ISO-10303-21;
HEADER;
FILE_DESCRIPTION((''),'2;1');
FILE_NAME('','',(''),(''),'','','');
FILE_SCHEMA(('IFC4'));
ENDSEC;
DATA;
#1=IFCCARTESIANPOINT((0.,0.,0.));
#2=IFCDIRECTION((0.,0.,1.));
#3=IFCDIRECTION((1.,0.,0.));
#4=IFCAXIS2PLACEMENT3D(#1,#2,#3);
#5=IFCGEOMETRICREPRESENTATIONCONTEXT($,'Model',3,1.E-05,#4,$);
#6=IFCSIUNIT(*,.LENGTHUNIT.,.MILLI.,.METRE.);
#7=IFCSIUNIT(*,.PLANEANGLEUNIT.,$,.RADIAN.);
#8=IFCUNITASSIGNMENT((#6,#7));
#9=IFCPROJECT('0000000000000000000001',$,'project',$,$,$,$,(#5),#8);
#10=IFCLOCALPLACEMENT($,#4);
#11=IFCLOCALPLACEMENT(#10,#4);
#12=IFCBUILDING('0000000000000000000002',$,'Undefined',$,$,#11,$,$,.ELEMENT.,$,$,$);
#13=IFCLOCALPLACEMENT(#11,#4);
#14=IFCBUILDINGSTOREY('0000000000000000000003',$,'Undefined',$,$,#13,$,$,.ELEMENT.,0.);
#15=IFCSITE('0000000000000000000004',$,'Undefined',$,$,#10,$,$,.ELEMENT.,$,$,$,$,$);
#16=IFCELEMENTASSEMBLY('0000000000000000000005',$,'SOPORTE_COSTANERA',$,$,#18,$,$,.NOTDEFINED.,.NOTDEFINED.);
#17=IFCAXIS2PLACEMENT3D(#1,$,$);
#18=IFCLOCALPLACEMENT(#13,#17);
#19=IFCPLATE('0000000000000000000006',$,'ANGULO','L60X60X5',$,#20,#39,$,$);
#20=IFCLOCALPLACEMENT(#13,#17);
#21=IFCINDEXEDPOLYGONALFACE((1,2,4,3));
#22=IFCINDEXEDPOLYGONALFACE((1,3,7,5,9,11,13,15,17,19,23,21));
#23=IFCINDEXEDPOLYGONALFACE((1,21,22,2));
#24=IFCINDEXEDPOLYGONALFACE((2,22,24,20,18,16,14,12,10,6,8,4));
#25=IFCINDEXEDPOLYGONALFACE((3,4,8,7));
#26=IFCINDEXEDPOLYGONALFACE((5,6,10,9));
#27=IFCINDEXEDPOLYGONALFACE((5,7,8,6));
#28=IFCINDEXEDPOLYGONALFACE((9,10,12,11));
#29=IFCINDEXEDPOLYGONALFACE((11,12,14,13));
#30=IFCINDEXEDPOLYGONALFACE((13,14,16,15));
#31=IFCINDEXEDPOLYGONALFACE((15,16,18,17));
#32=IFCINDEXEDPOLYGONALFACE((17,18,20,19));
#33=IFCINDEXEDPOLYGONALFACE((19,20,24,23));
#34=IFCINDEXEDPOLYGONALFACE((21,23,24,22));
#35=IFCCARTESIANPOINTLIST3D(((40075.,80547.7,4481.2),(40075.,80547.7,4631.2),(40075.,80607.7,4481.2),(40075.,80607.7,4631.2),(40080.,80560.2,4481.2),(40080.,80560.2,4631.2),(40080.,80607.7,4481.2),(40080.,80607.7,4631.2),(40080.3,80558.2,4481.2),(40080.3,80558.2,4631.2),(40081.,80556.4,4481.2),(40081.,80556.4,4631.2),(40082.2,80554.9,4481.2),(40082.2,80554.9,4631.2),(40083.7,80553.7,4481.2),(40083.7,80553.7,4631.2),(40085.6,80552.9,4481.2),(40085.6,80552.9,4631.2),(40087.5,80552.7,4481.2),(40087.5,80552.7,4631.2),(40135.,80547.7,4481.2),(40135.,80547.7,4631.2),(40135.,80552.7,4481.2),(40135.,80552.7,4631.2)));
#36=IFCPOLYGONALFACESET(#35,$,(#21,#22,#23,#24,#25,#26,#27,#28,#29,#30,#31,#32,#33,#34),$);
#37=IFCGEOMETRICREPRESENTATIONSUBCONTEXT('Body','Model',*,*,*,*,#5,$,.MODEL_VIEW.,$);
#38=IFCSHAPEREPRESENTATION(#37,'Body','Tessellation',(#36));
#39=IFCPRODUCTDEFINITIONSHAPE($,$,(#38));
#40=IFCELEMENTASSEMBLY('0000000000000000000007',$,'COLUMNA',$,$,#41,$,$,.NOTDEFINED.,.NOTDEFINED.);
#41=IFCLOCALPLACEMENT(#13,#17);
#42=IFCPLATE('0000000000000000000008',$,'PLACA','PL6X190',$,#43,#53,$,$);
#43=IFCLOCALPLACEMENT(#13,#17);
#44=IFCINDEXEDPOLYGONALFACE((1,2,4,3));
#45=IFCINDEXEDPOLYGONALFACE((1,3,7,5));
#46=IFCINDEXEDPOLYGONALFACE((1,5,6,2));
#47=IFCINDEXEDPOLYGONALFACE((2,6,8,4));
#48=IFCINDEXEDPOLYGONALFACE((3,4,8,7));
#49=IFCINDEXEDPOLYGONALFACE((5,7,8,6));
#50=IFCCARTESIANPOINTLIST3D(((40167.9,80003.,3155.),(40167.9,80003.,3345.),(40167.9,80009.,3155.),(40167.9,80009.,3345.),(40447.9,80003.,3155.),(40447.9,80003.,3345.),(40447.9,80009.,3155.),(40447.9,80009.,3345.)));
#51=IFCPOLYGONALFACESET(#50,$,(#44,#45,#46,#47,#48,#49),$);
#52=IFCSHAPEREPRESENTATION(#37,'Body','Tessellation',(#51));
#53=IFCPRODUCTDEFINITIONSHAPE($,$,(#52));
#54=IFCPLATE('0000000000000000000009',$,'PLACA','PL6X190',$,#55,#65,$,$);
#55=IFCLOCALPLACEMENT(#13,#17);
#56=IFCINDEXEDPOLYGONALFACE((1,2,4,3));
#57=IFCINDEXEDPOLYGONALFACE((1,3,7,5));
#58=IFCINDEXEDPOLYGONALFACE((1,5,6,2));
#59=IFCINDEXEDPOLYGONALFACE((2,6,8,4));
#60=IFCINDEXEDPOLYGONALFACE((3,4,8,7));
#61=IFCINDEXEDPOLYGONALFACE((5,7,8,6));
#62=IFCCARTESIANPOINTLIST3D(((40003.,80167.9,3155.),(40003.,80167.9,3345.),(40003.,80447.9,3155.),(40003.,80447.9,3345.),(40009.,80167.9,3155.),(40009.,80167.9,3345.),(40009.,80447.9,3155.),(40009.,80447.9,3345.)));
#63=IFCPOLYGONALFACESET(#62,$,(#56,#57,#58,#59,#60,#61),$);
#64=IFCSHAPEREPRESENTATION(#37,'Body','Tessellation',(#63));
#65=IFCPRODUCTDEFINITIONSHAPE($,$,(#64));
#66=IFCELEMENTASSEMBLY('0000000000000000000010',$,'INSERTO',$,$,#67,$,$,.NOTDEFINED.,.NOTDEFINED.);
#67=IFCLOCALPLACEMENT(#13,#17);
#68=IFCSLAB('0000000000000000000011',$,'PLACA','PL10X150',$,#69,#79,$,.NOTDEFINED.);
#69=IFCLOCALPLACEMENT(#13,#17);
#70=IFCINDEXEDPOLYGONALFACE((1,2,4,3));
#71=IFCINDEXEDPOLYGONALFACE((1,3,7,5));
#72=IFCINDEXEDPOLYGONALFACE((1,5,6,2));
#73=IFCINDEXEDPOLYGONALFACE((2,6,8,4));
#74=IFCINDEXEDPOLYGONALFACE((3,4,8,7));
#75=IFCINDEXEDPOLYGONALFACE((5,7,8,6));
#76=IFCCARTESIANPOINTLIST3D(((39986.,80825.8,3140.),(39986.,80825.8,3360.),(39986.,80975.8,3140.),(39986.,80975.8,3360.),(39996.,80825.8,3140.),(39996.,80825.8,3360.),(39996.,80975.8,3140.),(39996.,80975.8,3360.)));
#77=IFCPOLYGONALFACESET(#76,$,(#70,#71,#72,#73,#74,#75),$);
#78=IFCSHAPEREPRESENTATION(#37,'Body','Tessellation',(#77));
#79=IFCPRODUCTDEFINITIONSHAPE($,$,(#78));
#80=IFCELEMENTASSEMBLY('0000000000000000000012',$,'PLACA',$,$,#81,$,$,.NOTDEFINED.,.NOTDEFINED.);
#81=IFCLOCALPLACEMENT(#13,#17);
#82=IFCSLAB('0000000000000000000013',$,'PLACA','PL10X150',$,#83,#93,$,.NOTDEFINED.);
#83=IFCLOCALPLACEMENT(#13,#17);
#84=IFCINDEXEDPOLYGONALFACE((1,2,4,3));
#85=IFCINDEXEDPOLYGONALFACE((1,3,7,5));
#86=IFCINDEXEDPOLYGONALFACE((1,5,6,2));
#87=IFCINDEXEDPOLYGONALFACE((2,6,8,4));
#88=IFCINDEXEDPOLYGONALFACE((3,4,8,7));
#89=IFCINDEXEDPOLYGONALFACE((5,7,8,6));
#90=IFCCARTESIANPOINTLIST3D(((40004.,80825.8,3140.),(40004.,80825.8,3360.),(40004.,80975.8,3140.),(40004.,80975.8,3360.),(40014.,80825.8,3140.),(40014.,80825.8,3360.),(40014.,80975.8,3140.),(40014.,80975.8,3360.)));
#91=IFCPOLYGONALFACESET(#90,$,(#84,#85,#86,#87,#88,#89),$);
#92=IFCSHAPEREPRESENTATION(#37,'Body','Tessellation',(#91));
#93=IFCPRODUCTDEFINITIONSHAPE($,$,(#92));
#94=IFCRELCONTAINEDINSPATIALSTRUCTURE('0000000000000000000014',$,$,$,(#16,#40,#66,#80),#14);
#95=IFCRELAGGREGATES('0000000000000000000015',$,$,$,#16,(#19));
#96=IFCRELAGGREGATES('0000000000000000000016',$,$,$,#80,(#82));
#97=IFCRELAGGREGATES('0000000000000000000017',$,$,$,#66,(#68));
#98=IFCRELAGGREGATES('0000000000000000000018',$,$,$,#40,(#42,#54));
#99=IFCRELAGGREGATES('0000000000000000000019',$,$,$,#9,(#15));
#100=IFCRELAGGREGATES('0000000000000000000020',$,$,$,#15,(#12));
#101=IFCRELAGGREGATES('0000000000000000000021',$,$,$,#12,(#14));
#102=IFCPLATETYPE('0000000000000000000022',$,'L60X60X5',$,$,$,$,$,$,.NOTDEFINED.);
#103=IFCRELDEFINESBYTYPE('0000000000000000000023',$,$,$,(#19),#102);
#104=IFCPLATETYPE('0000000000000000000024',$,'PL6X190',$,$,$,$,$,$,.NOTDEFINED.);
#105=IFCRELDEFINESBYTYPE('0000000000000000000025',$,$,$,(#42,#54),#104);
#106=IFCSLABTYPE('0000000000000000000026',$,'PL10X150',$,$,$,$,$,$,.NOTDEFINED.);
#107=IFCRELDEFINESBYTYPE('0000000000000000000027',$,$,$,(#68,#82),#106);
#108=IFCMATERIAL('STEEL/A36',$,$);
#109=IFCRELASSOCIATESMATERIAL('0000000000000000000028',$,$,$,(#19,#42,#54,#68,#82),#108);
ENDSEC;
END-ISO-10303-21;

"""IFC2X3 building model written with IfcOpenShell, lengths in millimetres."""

from ifc_helpers import new_model, si_unit, frame, origin_with_axes, origin_2d_with_axis, place, context, subcontext, project, spatial, polyline, l_section, outline, extrude, material, type_object, element, aggregate, save


model = new_model("IFC2X3")

# Units and contexts
model_context = context("Model", 3, precision=1e-05, world=origin_with_axes())
body_context = subcontext(model_context, "Body", "Model", "MODEL_VIEW")
ifc_project = project(units=[si_unit("LENGTHUNIT", "METRE", prefix="MILLI"), si_unit("PLANEANGLEUNIT", "RADIAN")], contexts=[model_context])

# Site, building, storey
site_placement = place(None, origin_with_axes())
site = spatial("IfcSite", under=ifc_project, at=site_placement, Name="Undefined", CompositionType="ELEMENT")
building_placement = place(site_placement, origin_with_axes())
building = spatial("IfcBuilding", under=site, at=building_placement, Name="Undefined", CompositionType="ELEMENT")
storey_placement = place(building_placement, origin_with_axes())
storey = spatial("IfcBuildingStorey", under=building, at=storey_placement, Name="Undefined", CompositionType="ELEMENT", Elevation=0.0)

# Element assembly
assembly_1_placement = place(storey_placement, origin_with_axes())
assembly_1 = element("IfcElementAssembly", 1, at=assembly_1_placement, inside=storey, Name="SOPORTE_COSTANERA", AssemblyPlace="NOTDEFINED", PredefinedType="NOTDEFINED")
ifc_material_1 = material(Name="STEEL/A36")

# Plate
plate_type_1 = type_object("IfcPlateType", Name="L60X60X5", PredefinedType="NOTDEFINED")
plate_1_placement = place(assembly_1_placement, frame((40105.0, 80577.7, 4631.2), z_axis=(0.0, 1.0, 0.0), x_axis=(0.0, 0.0, -1.0)))
plate_1 = element("IfcPlate", 2, at=plate_1_placement, type_object=plate_type_1, material=ifc_material_1, Name="ANGULO", Description="L60X60X5", context=body_context, shape_type="SweptSolid", body=[
    extrude(l_section(Depth=60.0, Width=60.0, Thickness=5.0, FilletRadius=7.5, at=origin_2d_with_axis()), frame((150.0, 0.0, 0.0), z_axis=(-1.0, 0.0, 0.0), x_axis=(0.0, -1.0, 0.0)), (0.0, 0.0, 1.0), 150.0),
])
aggregate(assembly_1, [plate_1])

# Element assembly, plates
assembly_2_placement = place(storey_placement, origin_with_axes())
assembly_2 = element("IfcElementAssembly", 3, at=assembly_2_placement, inside=storey, Name="COLUMNA", AssemblyPlace="NOTDEFINED", PredefinedType="NOTDEFINED")
plate_type_2 = type_object("IfcPlateType", Name="PL6X190", PredefinedType="NOTDEFINED")
plate_2_placement = place(assembly_2_placement, frame((40447.9, 80006.0, 3250.0), z_axis=(0.0, 1.0, 0.0), x_axis=(-1.0, 0.0, 0.0)))
plate_2 = element("IfcPlate", 4, at=plate_2_placement, type_object=plate_type_2, material=ifc_material_1, Name="PLACA", Description="PL6X190", context=body_context, shape_type="SweptSolid", body=[
    extrude(outline(polyline([(0.0, -95.0), (0.0, 95.0), (280.0, 95.0), (280.0, -95.0), (0.0, -95.0)])), frame((0.0, 0.0, -3.0), z_axis=(0.0, 0.0, 1.0), x_axis=(1.0, 0.0, 0.0)), (0.0, 0.0, 1.0), 6.0),
])
plate_3_placement = place(assembly_2_placement, frame((40006.0, 80447.9, 3250.0), z_axis=(-1.0, 0.0, 0.0), x_axis=(0.0, -1.0, 0.0)))
plate_3 = element("IfcPlate", 5, at=plate_3_placement, type_object=plate_type_2, material=ifc_material_1, Name="PLACA", Description="PL6X190", context=body_context, shape_type="SweptSolid", body=[
    extrude(outline(polyline([(0.0, -95.0), (0.0, 95.0), (280.0, 95.0), (280.0, -95.0), (0.0, -95.0)])), frame((0.0, 0.0, -3.0), z_axis=(0.0, 0.0, 1.0), x_axis=(1.0, 0.0, 0.0)), (0.0, 0.0, 1.0), 6.0),
])

# Element assemblies, slabs
assembly_3_placement = place(storey_placement, origin_with_axes())
assembly_3 = element("IfcElementAssembly", 6, at=assembly_3_placement, inside=storey, Name="INSERTO", AssemblyPlace="NOTDEFINED", PredefinedType="NOTDEFINED")
slab_type = type_object("IfcSlabType", Name="PL10X150", PredefinedType="NOTDEFINED")
slab_1_placement = place(assembly_3_placement, frame((39991.0, 80975.8, 3360.0), z_axis=(1.0, -0.000015, 0.0), x_axis=(-0.000015, -1.0, 0.0)))
slab_1 = element("IfcSlab", 7, at=slab_1_placement, type_object=slab_type, material=ifc_material_1, Name="PLACA", Description="PL10X150", PredefinedType="NOTDEFINED", context=body_context, shape_type="SweptSolid", body=[
    extrude(outline(polyline([(0.0, 0.0), (150.0, 0.0), (150.0, 220.0), (0.0, 220.0), (0.0, 0.0)])), frame((0.0, 0.0, -5.0), z_axis=(0.0, 0.0, 1.0), x_axis=(1.0, 0.0, 0.0)), (0.0, 0.0, 1.0), 10.0),
])
assembly_4_placement = place(storey_placement, origin_with_axes())
assembly_4 = element("IfcElementAssembly", 8, at=assembly_4_placement, inside=storey, Name="PLACA", AssemblyPlace="NOTDEFINED", PredefinedType="NOTDEFINED")
slab_2_placement = place(assembly_4_placement, frame((40009.0, 80975.8, 3360.0), z_axis=(1.0, -0.000015, 0.0), x_axis=(-0.000015, -1.0, 0.0)))
slab_2 = element("IfcSlab", 9, at=slab_2_placement, type_object=slab_type, material=ifc_material_1, Name="PLACA", Description="PL10X150", PredefinedType="NOTDEFINED", context=body_context, shape_type="SweptSolid", body=[
    extrude(outline(polyline([(0.0, 0.0), (150.0, 0.0), (150.0, 220.0), (0.0, 220.0), (0.0, 0.0)])), frame((0.0, 0.0, -5.0), z_axis=(0.0, 0.0, 1.0), x_axis=(1.0, 0.0, 0.0)), (0.0, 0.0, 1.0), 10.0),
])
aggregate(assembly_4, [slab_2])

aggregate(assembly_3, [slab_1])
aggregate(assembly_2, [plate_2, plate_3])

save(model, "model.ifc")
